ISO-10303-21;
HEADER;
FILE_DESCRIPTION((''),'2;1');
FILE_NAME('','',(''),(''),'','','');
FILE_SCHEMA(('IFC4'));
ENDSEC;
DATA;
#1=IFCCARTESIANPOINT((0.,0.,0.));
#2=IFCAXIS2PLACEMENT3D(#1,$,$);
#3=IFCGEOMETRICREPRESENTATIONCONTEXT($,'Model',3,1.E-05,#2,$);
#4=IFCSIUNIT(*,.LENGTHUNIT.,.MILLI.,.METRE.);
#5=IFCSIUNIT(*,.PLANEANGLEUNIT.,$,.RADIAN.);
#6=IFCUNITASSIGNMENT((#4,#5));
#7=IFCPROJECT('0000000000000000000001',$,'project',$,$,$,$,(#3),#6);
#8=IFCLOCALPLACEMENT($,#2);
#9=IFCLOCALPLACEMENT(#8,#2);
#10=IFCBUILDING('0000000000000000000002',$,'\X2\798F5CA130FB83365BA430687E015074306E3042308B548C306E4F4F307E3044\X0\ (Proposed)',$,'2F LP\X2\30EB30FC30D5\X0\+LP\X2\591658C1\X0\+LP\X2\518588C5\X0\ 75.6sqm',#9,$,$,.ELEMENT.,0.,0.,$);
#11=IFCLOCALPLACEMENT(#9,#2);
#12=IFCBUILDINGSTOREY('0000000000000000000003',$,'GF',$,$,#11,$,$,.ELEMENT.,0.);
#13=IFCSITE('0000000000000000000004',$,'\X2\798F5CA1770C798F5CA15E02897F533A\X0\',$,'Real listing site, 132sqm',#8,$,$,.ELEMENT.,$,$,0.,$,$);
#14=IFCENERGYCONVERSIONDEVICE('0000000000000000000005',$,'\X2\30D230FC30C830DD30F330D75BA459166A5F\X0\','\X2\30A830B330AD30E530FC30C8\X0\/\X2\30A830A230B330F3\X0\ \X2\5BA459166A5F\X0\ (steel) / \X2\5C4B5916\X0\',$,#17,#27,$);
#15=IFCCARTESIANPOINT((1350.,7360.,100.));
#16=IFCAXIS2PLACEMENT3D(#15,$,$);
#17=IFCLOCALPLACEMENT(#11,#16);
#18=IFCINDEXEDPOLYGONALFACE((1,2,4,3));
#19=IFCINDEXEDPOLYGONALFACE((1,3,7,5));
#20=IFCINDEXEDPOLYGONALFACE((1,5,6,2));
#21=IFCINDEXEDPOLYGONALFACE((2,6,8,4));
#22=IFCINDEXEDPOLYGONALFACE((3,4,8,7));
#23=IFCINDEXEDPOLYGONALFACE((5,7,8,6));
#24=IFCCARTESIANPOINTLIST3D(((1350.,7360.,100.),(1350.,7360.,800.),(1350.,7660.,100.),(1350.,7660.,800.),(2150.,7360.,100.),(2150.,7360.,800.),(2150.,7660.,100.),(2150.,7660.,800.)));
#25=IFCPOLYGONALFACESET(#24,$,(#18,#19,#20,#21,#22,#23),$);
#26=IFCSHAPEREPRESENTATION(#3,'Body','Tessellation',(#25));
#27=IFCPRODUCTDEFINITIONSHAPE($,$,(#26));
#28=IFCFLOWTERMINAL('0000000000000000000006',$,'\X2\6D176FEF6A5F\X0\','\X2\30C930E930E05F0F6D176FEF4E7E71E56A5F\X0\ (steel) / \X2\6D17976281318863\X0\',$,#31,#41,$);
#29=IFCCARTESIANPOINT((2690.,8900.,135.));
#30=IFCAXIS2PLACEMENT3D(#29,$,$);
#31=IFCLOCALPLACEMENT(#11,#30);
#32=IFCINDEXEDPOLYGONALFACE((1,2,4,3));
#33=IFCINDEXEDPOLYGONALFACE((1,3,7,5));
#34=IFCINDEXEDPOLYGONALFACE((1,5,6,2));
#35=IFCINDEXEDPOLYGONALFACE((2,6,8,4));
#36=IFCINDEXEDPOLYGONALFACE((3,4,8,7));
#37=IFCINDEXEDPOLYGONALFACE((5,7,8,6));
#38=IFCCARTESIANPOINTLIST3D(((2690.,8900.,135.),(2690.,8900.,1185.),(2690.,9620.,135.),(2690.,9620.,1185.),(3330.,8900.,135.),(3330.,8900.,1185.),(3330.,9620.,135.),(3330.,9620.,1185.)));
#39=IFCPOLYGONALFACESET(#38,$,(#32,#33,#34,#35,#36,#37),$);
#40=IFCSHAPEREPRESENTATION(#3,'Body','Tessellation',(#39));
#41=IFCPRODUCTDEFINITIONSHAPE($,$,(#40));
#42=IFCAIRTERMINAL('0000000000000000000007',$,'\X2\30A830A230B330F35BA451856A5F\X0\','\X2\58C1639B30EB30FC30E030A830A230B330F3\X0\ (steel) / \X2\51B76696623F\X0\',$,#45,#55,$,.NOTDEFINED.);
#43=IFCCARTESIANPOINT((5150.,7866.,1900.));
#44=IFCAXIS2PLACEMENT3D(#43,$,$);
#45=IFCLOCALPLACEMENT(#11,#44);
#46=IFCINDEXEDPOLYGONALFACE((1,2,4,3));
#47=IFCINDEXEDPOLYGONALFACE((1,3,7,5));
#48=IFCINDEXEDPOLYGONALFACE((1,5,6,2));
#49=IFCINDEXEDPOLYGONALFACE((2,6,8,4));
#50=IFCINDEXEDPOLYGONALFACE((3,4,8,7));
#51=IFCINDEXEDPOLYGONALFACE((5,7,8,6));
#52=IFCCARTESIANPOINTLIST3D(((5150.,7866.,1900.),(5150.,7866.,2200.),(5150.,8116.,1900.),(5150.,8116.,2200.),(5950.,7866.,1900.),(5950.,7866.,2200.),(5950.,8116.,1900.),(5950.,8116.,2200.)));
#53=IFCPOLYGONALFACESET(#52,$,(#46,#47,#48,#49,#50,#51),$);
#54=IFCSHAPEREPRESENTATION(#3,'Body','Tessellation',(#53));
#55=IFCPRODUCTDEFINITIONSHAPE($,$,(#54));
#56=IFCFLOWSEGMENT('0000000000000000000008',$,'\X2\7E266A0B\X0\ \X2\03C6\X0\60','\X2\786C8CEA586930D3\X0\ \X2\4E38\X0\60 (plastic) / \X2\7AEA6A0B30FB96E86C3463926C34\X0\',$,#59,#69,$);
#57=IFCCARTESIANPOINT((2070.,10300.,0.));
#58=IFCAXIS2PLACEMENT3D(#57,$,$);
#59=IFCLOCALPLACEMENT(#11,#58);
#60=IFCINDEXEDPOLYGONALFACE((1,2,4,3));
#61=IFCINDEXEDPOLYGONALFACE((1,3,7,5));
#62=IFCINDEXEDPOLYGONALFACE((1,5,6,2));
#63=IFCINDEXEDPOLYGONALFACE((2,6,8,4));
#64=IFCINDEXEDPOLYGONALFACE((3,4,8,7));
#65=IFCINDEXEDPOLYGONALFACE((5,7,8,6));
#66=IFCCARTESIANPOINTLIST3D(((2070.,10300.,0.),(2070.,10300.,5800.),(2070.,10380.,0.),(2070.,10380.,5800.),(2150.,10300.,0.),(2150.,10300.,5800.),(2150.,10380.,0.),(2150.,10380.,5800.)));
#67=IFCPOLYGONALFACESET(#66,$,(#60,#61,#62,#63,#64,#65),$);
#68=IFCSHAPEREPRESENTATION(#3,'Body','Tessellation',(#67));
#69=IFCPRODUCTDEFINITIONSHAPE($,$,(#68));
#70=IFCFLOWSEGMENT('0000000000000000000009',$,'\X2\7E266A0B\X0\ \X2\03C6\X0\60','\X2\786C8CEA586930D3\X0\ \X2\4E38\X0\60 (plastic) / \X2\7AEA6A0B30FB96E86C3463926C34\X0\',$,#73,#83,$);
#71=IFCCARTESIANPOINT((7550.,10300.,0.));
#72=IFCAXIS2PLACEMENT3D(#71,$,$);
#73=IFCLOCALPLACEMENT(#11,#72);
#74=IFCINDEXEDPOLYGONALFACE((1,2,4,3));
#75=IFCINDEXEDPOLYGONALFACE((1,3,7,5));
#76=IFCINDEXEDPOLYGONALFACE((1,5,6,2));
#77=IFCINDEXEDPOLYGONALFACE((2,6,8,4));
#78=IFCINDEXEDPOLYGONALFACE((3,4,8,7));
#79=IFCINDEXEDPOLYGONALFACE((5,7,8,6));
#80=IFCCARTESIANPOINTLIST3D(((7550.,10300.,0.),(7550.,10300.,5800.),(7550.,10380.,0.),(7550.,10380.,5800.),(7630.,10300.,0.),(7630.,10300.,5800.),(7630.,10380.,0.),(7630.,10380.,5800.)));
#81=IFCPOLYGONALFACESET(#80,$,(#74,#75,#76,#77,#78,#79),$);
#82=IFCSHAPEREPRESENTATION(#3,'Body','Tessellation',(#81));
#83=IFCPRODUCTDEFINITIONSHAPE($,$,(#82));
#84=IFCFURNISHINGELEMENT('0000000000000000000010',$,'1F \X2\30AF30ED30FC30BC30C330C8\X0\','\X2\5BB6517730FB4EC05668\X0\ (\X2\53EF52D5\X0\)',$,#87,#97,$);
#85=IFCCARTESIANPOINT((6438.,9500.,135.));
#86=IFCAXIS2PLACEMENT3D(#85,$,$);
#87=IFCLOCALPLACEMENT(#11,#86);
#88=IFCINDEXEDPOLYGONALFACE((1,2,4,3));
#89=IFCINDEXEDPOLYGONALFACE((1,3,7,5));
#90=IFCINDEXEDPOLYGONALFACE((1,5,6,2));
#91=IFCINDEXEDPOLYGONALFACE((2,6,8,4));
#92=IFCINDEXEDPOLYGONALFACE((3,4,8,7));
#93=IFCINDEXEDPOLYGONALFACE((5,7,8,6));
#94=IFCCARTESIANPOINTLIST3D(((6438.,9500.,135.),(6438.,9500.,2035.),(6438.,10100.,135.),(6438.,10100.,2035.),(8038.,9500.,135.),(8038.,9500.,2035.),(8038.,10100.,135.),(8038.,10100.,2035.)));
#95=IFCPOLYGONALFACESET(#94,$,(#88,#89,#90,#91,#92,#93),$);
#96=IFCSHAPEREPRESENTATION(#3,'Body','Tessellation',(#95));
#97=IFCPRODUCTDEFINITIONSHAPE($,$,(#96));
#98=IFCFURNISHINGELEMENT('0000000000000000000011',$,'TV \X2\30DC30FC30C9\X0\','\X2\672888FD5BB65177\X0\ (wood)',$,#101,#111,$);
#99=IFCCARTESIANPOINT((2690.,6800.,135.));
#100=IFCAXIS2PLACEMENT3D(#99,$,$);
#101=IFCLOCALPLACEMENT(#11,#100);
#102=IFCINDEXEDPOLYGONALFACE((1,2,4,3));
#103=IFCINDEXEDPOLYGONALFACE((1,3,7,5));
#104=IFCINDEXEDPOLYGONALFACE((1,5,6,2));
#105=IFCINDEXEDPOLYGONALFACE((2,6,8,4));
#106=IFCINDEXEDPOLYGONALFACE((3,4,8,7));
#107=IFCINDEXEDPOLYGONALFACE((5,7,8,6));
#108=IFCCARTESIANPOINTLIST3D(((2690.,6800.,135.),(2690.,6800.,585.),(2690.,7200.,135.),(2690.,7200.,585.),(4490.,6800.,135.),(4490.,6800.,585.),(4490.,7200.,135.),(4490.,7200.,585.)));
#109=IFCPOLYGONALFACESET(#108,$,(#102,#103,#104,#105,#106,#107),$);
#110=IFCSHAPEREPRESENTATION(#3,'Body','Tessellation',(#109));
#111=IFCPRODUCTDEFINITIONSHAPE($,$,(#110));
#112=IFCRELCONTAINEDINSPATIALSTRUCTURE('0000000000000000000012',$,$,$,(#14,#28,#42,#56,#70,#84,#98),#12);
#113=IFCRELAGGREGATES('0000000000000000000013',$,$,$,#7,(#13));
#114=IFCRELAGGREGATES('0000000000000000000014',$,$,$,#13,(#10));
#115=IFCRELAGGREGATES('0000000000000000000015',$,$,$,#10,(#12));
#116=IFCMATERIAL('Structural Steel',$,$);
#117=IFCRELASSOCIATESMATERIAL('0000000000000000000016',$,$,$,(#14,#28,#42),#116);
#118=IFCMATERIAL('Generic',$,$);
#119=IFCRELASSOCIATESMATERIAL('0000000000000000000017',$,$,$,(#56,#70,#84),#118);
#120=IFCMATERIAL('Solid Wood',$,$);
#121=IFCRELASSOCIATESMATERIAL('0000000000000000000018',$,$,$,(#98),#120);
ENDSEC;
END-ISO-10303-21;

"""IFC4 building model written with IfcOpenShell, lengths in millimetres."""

from ifc_helpers import new_model, si_unit, frame, frame_2d, origin, place, context, project, spatial, rectangle, extrude, material, element, save


model = new_model("IFC4")

# Units and contexts
model_context = context("Model", 3, precision=1e-05, world=origin())
ifc_project = project(units=[si_unit("LENGTHUNIT", "METRE", prefix="MILLI"), si_unit("PLANEANGLEUNIT", "RADIAN")], contexts=[model_context])

# Site, building, storey
site_placement = place(None, origin())
site = spatial("IfcSite", under=ifc_project, at=site_placement, Name="福岡県福岡市西区", ObjectType="Real listing site, 132sqm", CompositionType="ELEMENT", RefElevation=0.0)
building_placement = place(site_placement, origin())
building = spatial("IfcBuilding", under=site, at=building_placement, Name="福岡・茶室と縁側のある和の住まい (Proposed)", ObjectType="2F LPルーフ+LP外壁+LP内装 75.6sqm", CompositionType="ELEMENT", ElevationOfRefHeight=0.0, ElevationOfTerrain=0.0)
storey_placement = place(building_placement, origin())
storey = spatial("IfcBuildingStorey", under=building, at=storey_placement, Name="GF", CompositionType="ELEMENT", Elevation=0.0)

# Shared definitions
ifc_material_1 = material(Name="Solid Wood")

# Shared definitions
ifc_material_2 = material(Name="Generic")

# Shared definitions
ifc_material_3 = material(Name="Structural Steel")

# Energy conversion device
energy_conversion_device_placement = place(storey_placement, frame((1350.0, 7360.0, 100.0)))
element("IfcEnergyConversionDevice", 1, at=energy_conversion_device_placement, inside=storey, material=ifc_material_3, Name="ヒートポンプ室外機", Description="エコキュート/エアコン 室外機 (steel) / 屋外", context=model_context, shape_type="SweptSolid", body=[
    extrude(rectangle(XDim=800.0, YDim=300.0, at=frame_2d((400.0, 150.0))), frame((1350.0, 7360.0, 100.0)), (0.0, 0.0, 1.0), 700.0),
])

# Flow terminal
flow_terminal_placement = place(storey_placement, frame((2690.0, 8900.0, 135.0)))
element("IfcFlowTerminal", 2, at=flow_terminal_placement, inside=storey, material=ifc_material_3, Name="洗濯機", Description="ドラム式洗濯乾燥機 (steel) / 洗面脱衣", context=model_context, shape_type="SweptSolid", body=[
    extrude(rectangle(XDim=640.0, YDim=720.0, at=frame_2d((320.0, 360.0))), frame((2690.0, 8900.0, 135.0)), (0.0, 0.0, 1.0), 1050.0),
])

# Air terminal
air_terminal_placement = place(storey_placement, frame((5150.0, 7866.0, 1900.0)))
element("IfcAirTerminal", 3, at=air_terminal_placement, inside=storey, material=ifc_material_3, Name="エアコン室内機", Description="壁掛ルームエアコン (steel) / 冷暖房", PredefinedType="NOTDEFINED", context=model_context, shape_type="SweptSolid", body=[
    extrude(rectangle(XDim=800.0, YDim=250.0, at=frame_2d((400.0, 125.0))), frame((5150.0, 7866.0, 1900.0)), (0.0, 0.0, 1.0), 300.0),
])

# Flow segments
flow_segment_1_placement = place(storey_placement, frame((2070.0, 10300.0, 0.0)))
element("IfcFlowSegment", 4, at=flow_segment_1_placement, inside=storey, material=ifc_material_2, Name="縦樋 φ60", Description="硬質塩ビ 丸60 (plastic) / 竪樋・雨水排水", context=model_context, shape_type="SweptSolid", body=[
    extrude(rectangle(XDim=80.0, YDim=80.0, at=frame_2d((40.0, 40.0))), frame((2070.0, 10300.0, 0.0)), (0.0, 0.0, 1.0), 5800.0),
])
flow_segment_2_placement = place(storey_placement, frame((7550.0, 10300.0, 0.0)))
element("IfcFlowSegment", 5, at=flow_segment_2_placement, inside=storey, material=ifc_material_2, Name="縦樋 φ60", Description="硬質塩ビ 丸60 (plastic) / 竪樋・雨水排水", context=model_context, shape_type="SweptSolid", body=[
    extrude(rectangle(XDim=80.0, YDim=80.0, at=frame_2d((40.0, 40.0))), frame((7550.0, 10300.0, 0.0)), (0.0, 0.0, 1.0), 5800.0),
])

# Furnishing elements
furnishing_1_placement = place(storey_placement, frame((6438.0, 9500.0, 135.0)))
element("IfcFurnishingElement", 6, at=furnishing_1_placement, inside=storey, material=ifc_material_2, Name="1F クローゼット", Description="家具・什器 (可動)", context=model_context, shape_type="SweptSolid", body=[
    extrude(rectangle(XDim=1600.0, YDim=600.0, at=frame_2d((800.0, 300.0))), frame((6438.0, 9500.0, 135.0)), (0.0, 0.0, 1.0), 1900.0),
])
furnishing_2_placement = place(storey_placement, frame((2690.0, 6800.0, 135.0)))
element("IfcFurnishingElement", 7, at=furnishing_2_placement, inside=storey, material=ifc_material_1, Name="TV ボード", Description="木製家具 (wood)", context=model_context, shape_type="SweptSolid", body=[
    extrude(rectangle(XDim=1800.0, YDim=400.0, at=frame_2d((900.0, 200.0))), frame((2690.0, 6800.0, 135.0)), (0.0, 0.0, 1.0), 450.0),
])

save(model, "model.ifc")
